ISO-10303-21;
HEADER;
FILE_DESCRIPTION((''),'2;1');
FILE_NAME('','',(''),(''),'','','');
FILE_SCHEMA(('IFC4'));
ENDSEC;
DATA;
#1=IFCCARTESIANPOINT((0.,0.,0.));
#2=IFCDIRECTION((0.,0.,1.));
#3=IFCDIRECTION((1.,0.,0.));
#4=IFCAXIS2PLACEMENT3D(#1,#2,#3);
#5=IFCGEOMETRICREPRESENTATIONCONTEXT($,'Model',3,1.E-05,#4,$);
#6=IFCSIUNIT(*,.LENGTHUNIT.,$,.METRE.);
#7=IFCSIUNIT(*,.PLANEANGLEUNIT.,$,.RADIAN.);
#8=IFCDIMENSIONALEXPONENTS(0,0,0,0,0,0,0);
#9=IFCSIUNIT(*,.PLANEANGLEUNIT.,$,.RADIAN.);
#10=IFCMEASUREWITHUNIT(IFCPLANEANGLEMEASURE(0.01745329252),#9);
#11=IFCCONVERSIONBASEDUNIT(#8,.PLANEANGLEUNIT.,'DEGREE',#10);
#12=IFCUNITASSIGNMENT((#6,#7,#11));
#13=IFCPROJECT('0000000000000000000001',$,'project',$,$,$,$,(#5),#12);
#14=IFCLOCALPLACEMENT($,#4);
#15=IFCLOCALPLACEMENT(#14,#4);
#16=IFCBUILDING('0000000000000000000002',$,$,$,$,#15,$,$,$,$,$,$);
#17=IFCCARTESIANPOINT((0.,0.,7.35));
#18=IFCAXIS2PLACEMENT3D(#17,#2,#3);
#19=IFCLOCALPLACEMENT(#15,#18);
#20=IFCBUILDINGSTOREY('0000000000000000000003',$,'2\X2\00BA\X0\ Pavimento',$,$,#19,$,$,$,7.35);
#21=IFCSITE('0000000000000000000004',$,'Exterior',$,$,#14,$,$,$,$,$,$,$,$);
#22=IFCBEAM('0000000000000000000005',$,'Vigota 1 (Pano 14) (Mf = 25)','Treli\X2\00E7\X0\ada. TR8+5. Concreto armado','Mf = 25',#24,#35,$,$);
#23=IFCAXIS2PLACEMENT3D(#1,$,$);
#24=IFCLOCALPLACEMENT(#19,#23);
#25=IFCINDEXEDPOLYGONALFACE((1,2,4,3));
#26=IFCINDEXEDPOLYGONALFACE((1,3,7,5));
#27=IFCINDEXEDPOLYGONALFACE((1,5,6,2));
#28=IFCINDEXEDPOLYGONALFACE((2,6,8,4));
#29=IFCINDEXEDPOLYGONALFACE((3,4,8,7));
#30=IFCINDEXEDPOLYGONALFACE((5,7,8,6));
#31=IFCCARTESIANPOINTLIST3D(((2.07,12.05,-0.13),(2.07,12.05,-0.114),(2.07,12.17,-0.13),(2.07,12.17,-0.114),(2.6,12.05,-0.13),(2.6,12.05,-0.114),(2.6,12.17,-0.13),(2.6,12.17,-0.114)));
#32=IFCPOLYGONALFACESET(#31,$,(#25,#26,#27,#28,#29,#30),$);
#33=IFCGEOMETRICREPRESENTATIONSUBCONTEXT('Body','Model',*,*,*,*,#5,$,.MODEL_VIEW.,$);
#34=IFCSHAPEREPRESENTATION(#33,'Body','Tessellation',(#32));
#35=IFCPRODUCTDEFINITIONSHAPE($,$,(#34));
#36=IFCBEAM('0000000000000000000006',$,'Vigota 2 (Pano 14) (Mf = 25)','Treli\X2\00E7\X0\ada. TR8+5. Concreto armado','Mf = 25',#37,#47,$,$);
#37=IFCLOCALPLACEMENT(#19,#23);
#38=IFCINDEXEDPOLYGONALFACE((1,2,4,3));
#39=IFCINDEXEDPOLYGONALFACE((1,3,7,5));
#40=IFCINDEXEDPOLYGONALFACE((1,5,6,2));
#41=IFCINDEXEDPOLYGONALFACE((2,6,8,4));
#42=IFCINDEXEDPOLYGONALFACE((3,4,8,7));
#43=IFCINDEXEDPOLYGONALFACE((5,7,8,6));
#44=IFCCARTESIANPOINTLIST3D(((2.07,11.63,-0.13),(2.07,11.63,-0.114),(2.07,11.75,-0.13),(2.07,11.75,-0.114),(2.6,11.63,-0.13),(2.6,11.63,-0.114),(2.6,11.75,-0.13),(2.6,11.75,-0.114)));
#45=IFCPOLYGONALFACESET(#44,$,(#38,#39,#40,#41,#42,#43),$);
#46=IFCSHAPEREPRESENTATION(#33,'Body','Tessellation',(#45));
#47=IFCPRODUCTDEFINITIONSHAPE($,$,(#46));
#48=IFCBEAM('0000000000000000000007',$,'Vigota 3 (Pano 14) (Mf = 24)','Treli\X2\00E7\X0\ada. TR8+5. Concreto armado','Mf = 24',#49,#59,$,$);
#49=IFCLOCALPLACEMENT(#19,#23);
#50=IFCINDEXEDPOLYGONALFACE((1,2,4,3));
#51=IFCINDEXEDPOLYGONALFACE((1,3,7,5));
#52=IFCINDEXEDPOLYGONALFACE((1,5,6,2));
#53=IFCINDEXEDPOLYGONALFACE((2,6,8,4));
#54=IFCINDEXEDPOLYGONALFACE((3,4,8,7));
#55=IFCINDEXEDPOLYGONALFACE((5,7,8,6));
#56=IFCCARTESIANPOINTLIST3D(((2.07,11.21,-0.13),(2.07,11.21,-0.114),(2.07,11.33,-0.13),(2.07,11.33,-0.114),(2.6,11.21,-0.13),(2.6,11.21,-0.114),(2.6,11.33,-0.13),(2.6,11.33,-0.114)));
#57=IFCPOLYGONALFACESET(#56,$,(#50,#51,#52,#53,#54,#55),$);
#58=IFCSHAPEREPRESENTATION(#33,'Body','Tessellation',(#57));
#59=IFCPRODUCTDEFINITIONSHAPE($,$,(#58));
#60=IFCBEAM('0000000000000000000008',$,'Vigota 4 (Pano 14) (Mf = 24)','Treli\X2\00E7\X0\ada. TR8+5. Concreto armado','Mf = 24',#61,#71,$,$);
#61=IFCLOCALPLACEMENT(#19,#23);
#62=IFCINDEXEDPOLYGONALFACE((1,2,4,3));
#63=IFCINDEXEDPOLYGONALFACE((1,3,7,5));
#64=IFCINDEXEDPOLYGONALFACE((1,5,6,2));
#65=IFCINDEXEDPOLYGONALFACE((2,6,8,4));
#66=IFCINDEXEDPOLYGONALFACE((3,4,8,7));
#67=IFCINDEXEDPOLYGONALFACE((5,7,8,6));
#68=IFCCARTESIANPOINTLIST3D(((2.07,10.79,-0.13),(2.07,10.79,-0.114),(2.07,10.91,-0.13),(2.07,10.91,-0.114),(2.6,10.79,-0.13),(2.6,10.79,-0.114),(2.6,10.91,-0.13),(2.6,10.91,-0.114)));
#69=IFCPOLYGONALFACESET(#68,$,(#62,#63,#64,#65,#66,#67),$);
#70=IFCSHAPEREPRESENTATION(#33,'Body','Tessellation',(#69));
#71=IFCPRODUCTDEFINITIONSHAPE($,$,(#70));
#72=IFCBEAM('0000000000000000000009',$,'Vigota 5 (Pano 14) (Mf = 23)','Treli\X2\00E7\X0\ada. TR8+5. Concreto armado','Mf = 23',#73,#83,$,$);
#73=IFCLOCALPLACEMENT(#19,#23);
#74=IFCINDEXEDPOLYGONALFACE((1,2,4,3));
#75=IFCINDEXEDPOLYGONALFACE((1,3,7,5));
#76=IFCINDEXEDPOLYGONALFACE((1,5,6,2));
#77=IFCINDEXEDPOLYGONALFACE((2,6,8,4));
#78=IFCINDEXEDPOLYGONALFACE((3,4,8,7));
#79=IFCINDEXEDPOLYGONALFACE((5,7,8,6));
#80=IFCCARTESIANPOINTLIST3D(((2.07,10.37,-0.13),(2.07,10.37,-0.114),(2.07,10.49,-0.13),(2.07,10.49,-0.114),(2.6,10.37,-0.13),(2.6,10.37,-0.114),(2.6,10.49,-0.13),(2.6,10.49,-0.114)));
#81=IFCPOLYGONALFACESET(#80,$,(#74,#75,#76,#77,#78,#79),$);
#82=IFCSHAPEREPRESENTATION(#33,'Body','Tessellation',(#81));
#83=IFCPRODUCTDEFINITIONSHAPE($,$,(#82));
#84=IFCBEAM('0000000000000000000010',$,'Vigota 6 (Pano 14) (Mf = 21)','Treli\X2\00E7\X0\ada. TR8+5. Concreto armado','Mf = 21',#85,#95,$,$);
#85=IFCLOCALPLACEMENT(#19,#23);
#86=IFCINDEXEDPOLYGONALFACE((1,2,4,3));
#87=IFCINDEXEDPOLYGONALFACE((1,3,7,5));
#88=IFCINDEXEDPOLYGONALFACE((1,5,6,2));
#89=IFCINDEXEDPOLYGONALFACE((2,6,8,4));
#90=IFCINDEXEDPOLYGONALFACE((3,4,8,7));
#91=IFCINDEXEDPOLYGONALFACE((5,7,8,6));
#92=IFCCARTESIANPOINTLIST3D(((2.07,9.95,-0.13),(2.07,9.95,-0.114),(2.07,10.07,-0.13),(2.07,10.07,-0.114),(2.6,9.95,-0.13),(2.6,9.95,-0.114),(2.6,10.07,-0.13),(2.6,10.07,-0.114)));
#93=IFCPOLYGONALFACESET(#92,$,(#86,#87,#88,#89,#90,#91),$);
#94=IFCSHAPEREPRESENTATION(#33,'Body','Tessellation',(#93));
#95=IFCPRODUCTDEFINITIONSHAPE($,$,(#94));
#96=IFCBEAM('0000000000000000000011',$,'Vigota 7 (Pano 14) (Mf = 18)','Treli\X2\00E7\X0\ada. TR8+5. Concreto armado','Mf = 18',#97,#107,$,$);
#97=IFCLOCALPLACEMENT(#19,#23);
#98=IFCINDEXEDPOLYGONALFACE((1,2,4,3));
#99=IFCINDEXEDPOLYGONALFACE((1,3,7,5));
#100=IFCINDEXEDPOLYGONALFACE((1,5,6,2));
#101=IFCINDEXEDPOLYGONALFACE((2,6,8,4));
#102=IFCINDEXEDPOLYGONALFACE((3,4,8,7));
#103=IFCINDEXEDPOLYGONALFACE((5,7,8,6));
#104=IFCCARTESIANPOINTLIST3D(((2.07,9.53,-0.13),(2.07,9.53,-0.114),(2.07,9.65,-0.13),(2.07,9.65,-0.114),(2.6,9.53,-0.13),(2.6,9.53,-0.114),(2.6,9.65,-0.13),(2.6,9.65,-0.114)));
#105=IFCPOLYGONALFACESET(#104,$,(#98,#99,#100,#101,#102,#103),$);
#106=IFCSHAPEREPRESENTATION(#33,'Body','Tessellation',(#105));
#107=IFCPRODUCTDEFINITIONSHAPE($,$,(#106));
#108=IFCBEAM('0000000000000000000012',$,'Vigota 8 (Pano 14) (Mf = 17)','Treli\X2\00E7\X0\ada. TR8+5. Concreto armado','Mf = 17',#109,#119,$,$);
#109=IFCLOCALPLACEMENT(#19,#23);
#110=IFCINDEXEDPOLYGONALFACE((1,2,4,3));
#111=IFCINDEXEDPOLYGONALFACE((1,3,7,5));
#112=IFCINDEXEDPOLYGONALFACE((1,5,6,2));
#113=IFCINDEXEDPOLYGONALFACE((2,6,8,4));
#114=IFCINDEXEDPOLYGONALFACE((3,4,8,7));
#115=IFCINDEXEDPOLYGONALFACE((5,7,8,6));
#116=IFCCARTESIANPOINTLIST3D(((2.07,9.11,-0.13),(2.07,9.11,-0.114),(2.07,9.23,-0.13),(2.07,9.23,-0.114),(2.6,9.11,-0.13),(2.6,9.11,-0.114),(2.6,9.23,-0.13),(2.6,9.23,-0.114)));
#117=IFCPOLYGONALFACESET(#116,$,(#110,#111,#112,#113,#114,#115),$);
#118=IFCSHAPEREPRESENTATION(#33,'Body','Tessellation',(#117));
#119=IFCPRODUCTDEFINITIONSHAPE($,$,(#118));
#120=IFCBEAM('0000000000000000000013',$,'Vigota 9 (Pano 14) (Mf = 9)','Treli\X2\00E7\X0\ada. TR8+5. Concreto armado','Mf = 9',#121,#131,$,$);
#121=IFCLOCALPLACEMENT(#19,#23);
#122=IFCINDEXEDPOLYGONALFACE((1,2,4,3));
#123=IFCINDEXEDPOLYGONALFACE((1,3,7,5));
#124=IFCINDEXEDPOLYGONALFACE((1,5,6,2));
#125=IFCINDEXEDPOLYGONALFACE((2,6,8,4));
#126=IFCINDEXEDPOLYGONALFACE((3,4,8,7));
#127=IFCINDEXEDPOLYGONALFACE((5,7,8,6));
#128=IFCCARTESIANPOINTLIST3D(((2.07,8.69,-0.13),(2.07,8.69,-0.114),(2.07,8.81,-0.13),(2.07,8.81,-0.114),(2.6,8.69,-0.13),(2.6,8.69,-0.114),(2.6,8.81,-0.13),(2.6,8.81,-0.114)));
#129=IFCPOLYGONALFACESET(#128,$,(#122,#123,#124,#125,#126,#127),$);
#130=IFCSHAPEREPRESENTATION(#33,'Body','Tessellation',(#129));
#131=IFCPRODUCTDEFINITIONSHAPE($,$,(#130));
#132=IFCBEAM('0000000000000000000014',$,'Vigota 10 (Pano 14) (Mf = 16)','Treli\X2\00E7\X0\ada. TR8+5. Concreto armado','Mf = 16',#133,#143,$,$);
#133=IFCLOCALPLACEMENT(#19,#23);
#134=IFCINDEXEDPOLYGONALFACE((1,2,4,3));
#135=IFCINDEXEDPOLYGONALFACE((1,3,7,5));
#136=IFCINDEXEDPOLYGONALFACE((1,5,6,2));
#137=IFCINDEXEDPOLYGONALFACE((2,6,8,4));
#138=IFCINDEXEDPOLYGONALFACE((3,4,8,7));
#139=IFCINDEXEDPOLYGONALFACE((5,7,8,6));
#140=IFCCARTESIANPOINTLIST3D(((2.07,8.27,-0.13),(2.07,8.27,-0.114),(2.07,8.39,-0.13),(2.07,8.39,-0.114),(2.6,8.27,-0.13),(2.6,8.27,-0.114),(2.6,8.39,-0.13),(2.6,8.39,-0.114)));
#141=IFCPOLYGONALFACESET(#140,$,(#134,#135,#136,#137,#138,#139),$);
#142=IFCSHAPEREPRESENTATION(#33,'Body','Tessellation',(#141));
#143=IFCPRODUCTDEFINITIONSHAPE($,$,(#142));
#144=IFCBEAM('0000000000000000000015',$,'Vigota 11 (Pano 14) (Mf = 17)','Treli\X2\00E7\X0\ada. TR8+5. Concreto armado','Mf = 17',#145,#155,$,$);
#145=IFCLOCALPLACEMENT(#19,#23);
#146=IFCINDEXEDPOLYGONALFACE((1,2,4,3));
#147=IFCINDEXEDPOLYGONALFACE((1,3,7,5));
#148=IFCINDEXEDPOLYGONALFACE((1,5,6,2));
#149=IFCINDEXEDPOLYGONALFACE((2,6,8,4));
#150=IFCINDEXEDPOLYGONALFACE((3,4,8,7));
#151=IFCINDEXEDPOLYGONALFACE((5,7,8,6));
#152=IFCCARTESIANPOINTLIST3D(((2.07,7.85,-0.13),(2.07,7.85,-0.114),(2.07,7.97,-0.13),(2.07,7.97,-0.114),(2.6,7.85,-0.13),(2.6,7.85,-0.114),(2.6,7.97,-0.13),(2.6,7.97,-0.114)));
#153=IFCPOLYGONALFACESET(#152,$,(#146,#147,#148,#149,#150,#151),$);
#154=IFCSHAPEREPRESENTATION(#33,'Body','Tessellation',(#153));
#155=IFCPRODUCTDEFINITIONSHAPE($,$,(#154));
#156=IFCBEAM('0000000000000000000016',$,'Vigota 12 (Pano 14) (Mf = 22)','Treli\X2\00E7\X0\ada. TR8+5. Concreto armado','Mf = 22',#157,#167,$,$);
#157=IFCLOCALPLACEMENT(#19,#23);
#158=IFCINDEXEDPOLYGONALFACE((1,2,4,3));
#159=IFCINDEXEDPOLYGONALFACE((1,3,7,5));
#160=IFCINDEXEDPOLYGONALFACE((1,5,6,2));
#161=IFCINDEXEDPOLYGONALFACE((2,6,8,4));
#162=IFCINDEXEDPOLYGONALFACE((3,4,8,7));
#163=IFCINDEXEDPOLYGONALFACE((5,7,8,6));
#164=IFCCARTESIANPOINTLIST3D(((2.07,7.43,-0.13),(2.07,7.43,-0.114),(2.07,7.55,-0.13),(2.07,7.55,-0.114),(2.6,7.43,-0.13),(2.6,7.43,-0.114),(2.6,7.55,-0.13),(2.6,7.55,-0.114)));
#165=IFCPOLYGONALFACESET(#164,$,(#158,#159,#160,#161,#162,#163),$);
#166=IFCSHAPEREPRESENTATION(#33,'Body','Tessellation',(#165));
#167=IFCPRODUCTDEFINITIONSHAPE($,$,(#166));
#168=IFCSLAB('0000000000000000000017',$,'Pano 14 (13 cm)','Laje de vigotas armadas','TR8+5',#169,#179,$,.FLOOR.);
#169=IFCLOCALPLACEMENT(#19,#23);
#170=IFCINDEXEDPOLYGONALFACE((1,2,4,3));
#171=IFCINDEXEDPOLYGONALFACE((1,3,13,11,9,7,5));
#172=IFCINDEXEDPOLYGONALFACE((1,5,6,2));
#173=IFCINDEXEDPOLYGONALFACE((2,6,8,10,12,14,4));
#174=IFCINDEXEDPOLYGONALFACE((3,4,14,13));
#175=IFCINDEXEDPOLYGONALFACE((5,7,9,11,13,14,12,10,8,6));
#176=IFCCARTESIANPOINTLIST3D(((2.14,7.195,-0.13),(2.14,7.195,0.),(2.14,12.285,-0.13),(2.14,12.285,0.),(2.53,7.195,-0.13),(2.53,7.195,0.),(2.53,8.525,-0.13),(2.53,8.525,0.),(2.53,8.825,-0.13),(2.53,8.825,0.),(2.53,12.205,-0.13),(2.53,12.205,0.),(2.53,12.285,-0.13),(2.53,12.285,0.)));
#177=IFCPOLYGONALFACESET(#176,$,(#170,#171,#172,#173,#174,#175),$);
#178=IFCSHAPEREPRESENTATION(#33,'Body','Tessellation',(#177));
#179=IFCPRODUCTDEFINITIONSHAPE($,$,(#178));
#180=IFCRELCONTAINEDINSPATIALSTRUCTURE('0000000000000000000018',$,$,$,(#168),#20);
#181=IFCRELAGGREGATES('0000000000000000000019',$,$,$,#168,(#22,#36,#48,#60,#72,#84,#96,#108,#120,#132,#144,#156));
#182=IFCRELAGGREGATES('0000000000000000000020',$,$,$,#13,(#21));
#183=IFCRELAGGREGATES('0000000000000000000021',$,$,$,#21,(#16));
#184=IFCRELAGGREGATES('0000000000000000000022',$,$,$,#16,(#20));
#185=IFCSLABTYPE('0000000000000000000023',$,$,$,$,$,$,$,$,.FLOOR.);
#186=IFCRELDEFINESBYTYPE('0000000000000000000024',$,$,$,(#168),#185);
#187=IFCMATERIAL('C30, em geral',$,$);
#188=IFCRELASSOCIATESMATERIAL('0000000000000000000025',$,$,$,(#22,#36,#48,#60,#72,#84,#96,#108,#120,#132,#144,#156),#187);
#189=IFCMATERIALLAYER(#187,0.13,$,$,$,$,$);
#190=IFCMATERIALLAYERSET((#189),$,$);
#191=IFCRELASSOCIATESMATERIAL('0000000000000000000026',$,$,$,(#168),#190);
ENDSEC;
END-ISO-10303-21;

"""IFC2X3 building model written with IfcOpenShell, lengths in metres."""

from ifc_helpers import new_model, entity, si_unit, converted_unit, frame, origin_with_axes, place, context, subcontext, project, spatial, polyline, outline, extrude, material, layer, layer_set, layer_usage, type_object, element, aggregate, save


model = new_model("IFC2X3")

# Units and contexts
model_context = context("Model", 3, precision=1e-05, world=origin_with_axes())
body_context = subcontext(model_context, "Body", "Model", "MODEL_VIEW")
ifc_project = project(units=[si_unit("LENGTHUNIT", "METRE"), si_unit("PLANEANGLEUNIT", "RADIAN"), converted_unit("PLANEANGLEUNIT", "DEGREE", entity("IfcPlaneAngleMeasure", 0.01745329252), si_unit("PLANEANGLEUNIT", "RADIAN"), dimensions=[0, 0, 0, 0, 0, 0, 0])], contexts=[model_context])

# Beams
ifc_material = material(Name="C30, em geral")
site_placement = place(None, origin_with_axes())
building_placement = place(site_placement, origin_with_axes())
storey_placement = place(building_placement, frame((0.0, 0.0, 7.35), z_axis=(0.0, 0.0, 1.0), x_axis=(1.0, 0.0, 0.0)))
beam_1_placement = place(storey_placement, frame((2.07, 12.11, -0.122), z_axis=(1.0, 0.0, 0.0), x_axis=(0.0, 1.0, 0.0)))
beam_1 = element("IfcBeam", 1, at=beam_1_placement, material=ifc_material, Name="Vigota 1 (Pano 14) (Mf = 25)", Description="Treliçada. TR8+5. Concreto armado", ObjectType="Mf = 25", context=body_context, shape_type="SweptSolid", body=[
    extrude(outline(polyline([(0.06, 0.008), (-0.06, 0.008), (-0.06, -0.008), (0.06, -0.008), (0.06, 0.008)])), origin_with_axes(), (0.0, 0.0, 1.0), 0.53),
])
beam_2_placement = place(storey_placement, frame((2.07, 11.69, -0.122), z_axis=(1.0, 0.0, 0.0), x_axis=(0.0, 1.0, 0.0)))
beam_2 = element("IfcBeam", 2, at=beam_2_placement, material=ifc_material, Name="Vigota 2 (Pano 14) (Mf = 25)", Description="Treliçada. TR8+5. Concreto armado", ObjectType="Mf = 25", context=body_context, shape_type="SweptSolid", body=[
    extrude(outline(polyline([(0.06, 0.008), (-0.06, 0.008), (-0.06, -0.008), (0.06, -0.008), (0.06, 0.008)])), origin_with_axes(), (0.0, 0.0, 1.0), 0.53),
])
beam_3_placement = place(storey_placement, frame((2.07, 11.27, -0.122), z_axis=(1.0, 0.0, 0.0), x_axis=(0.0, 1.0, 0.0)))
beam_3 = element("IfcBeam", 3, at=beam_3_placement, material=ifc_material, Name="Vigota 3 (Pano 14) (Mf = 24)", Description="Treliçada. TR8+5. Concreto armado", ObjectType="Mf = 24", context=body_context, shape_type="SweptSolid", body=[
    extrude(outline(polyline([(0.06, 0.008), (-0.06, 0.008), (-0.06, -0.008), (0.06, -0.008), (0.06, 0.008)])), origin_with_axes(), (0.0, 0.0, 1.0), 0.53),
])
beam_4_placement = place(storey_placement, frame((2.07, 10.85, -0.122), z_axis=(1.0, 0.0, 0.0), x_axis=(0.0, 1.0, 0.0)))
beam_4 = element("IfcBeam", 4, at=beam_4_placement, material=ifc_material, Name="Vigota 4 (Pano 14) (Mf = 24)", Description="Treliçada. TR8+5. Concreto armado", ObjectType="Mf = 24", context=body_context, shape_type="SweptSolid", body=[
    extrude(outline(polyline([(0.06, 0.008), (-0.06, 0.008), (-0.06, -0.008), (0.06, -0.008), (0.06, 0.008)])), origin_with_axes(), (0.0, 0.0, 1.0), 0.53),
])
beam_5_placement = place(storey_placement, frame((2.07, 10.43, -0.122), z_axis=(1.0, 0.0, 0.0), x_axis=(0.0, 1.0, 0.0)))
beam_5 = element("IfcBeam", 5, at=beam_5_placement, material=ifc_material, Name="Vigota 5 (Pano 14) (Mf = 23)", Description="Treliçada. TR8+5. Concreto armado", ObjectType="Mf = 23", context=body_context, shape_type="SweptSolid", body=[
    extrude(outline(polyline([(0.06, 0.008), (-0.06, 0.008), (-0.06, -0.008), (0.06, -0.008), (0.06, 0.008)])), origin_with_axes(), (0.0, 0.0, 1.0), 0.53),
])
beam_6_placement = place(storey_placement, frame((2.07, 10.01, -0.122), z_axis=(1.0, 0.0, 0.0), x_axis=(0.0, 1.0, 0.0)))
beam_6 = element("IfcBeam", 6, at=beam_6_placement, material=ifc_material, Name="Vigota 6 (Pano 14) (Mf = 21)", Description="Treliçada. TR8+5. Concreto armado", ObjectType="Mf = 21", context=body_context, shape_type="SweptSolid", body=[
    extrude(outline(polyline([(0.06, 0.008), (-0.06, 0.008), (-0.06, -0.008), (0.06, -0.008), (0.06, 0.008)])), origin_with_axes(), (0.0, 0.0, 1.0), 0.53),
])
beam_7_placement = place(storey_placement, frame((2.07, 9.59, -0.122), z_axis=(1.0, 0.0, 0.0), x_axis=(0.0, 1.0, 0.0)))
beam_7 = element("IfcBeam", 7, at=beam_7_placement, material=ifc_material, Name="Vigota 7 (Pano 14) (Mf = 18)", Description="Treliçada. TR8+5. Concreto armado", ObjectType="Mf = 18", context=body_context, shape_type="SweptSolid", body=[
    extrude(outline(polyline([(0.06, 0.008), (-0.06, 0.008), (-0.06, -0.008), (0.06, -0.008), (0.06, 0.008)])), origin_with_axes(), (0.0, 0.0, 1.0), 0.53),
])
beam_8_placement = place(storey_placement, frame((2.07, 9.17, -0.122), z_axis=(1.0, 0.0, 0.0), x_axis=(0.0, 1.0, 0.0)))
beam_8 = element("IfcBeam", 8, at=beam_8_placement, material=ifc_material, Name="Vigota 8 (Pano 14) (Mf = 17)", Description="Treliçada. TR8+5. Concreto armado", ObjectType="Mf = 17", context=body_context, shape_type="SweptSolid", body=[
    extrude(outline(polyline([(0.06, 0.008), (-0.06, 0.008), (-0.06, -0.008), (0.06, -0.008), (0.06, 0.008)])), origin_with_axes(), (0.0, 0.0, 1.0), 0.53),
])
beam_9_placement = place(storey_placement, frame((2.07, 8.75, -0.122), z_axis=(1.0, 0.0, 0.0), x_axis=(0.0, 1.0, 0.0)))
beam_9 = element("IfcBeam", 9, at=beam_9_placement, material=ifc_material, Name="Vigota 9 (Pano 14) (Mf = 9)", Description="Treliçada. TR8+5. Concreto armado", ObjectType="Mf = 9", context=body_context, shape_type="SweptSolid", body=[
    extrude(outline(polyline([(0.06, 0.008), (-0.06, 0.008), (-0.06, -0.008), (0.06, -0.008), (0.06, 0.008)])), origin_with_axes(), (0.0, 0.0, 1.0), 0.53),
])
beam_10_placement = place(storey_placement, frame((2.07, 8.33, -0.122), z_axis=(1.0, 0.0, 0.0), x_axis=(0.0, 1.0, 0.0)))
beam_10 = element("IfcBeam", 10, at=beam_10_placement, material=ifc_material, Name="Vigota 10 (Pano 14) (Mf = 16)", Description="Treliçada. TR8+5. Concreto armado", ObjectType="Mf = 16", context=body_context, shape_type="SweptSolid", body=[
    extrude(outline(polyline([(0.06, 0.008), (-0.06, 0.008), (-0.06, -0.008), (0.06, -0.008), (0.06, 0.008)])), origin_with_axes(), (0.0, 0.0, 1.0), 0.53),
])
beam_11_placement = place(storey_placement, frame((2.07, 7.91, -0.122), z_axis=(1.0, 0.0, 0.0), x_axis=(0.0, 1.0, 0.0)))
beam_11 = element("IfcBeam", 11, at=beam_11_placement, material=ifc_material, Name="Vigota 11 (Pano 14) (Mf = 17)", Description="Treliçada. TR8+5. Concreto armado", ObjectType="Mf = 17", context=body_context, shape_type="SweptSolid", body=[
    extrude(outline(polyline([(0.06, 0.008), (-0.06, 0.008), (-0.06, -0.008), (0.06, -0.008), (0.06, 0.008)])), origin_with_axes(), (0.0, 0.0, 1.0), 0.53),
])
beam_12_placement = place(storey_placement, frame((2.07, 7.49, -0.122), z_axis=(1.0, 0.0, 0.0), x_axis=(0.0, 1.0, 0.0)))
beam_12 = element("IfcBeam", 12, at=beam_12_placement, material=ifc_material, Name="Vigota 12 (Pano 14) (Mf = 22)", Description="Treliçada. TR8+5. Concreto armado", ObjectType="Mf = 22", context=body_context, shape_type="SweptSolid", body=[
    extrude(outline(polyline([(0.06, 0.008), (-0.06, 0.008), (-0.06, -0.008), (0.06, -0.008), (0.06, 0.008)])), origin_with_axes(), (0.0, 0.0, 1.0), 0.53),
])

# Site, building, storey
site = spatial("IfcSite", under=ifc_project, at=site_placement, Name="Exterior")
building = spatial("IfcBuilding", under=site, at=building_placement)
storey = spatial("IfcBuildingStorey", under=building, at=storey_placement, Name="2º Pavimento", Elevation=7.35)

# Slab
ifc_layer_1 = layer(ifc_material, 0.13)
ifc_layer_set_1 = layer_set([ifc_layer_1])
ifc_layer_usage_1 = layer_usage(ifc_layer_set_1, "AXIS3", "POSITIVE", 0.0)
slab_type = type_object("IfcSlabType", PredefinedType="FLOOR")
slab_1_placement = place(storey_placement, frame((0.0, 0.0, -0.13), z_axis=(0.0, 0.0, 1.0), x_axis=(1.0, 0.0, 0.0)))
slab_1 = element("IfcSlab", 13, at=slab_1_placement, inside=storey, type_object=slab_type, material=ifc_layer_usage_1, Name="Pano 14 (13 cm)", Description="Laje de vigotas armadas", ObjectType="TR8+5", PredefinedType="FLOOR", context=body_context, shape_type="SweptSolid", body=[
    extrude(outline(polyline([(2.53, 8.525), (2.53, 8.825), (2.53, 12.205), (2.53, 12.285), (2.14, 12.285), (2.14, 7.195), (2.53, 7.195), (2.53, 8.525)])), origin_with_axes(), (0.0, 0.0, 1.0), 0.13),
])
aggregate(slab_1, [beam_1, beam_2, beam_3, beam_4, beam_5, beam_6, beam_7, beam_8, beam_9, beam_10, beam_11, beam_12])

save(model, "model.ifc")
